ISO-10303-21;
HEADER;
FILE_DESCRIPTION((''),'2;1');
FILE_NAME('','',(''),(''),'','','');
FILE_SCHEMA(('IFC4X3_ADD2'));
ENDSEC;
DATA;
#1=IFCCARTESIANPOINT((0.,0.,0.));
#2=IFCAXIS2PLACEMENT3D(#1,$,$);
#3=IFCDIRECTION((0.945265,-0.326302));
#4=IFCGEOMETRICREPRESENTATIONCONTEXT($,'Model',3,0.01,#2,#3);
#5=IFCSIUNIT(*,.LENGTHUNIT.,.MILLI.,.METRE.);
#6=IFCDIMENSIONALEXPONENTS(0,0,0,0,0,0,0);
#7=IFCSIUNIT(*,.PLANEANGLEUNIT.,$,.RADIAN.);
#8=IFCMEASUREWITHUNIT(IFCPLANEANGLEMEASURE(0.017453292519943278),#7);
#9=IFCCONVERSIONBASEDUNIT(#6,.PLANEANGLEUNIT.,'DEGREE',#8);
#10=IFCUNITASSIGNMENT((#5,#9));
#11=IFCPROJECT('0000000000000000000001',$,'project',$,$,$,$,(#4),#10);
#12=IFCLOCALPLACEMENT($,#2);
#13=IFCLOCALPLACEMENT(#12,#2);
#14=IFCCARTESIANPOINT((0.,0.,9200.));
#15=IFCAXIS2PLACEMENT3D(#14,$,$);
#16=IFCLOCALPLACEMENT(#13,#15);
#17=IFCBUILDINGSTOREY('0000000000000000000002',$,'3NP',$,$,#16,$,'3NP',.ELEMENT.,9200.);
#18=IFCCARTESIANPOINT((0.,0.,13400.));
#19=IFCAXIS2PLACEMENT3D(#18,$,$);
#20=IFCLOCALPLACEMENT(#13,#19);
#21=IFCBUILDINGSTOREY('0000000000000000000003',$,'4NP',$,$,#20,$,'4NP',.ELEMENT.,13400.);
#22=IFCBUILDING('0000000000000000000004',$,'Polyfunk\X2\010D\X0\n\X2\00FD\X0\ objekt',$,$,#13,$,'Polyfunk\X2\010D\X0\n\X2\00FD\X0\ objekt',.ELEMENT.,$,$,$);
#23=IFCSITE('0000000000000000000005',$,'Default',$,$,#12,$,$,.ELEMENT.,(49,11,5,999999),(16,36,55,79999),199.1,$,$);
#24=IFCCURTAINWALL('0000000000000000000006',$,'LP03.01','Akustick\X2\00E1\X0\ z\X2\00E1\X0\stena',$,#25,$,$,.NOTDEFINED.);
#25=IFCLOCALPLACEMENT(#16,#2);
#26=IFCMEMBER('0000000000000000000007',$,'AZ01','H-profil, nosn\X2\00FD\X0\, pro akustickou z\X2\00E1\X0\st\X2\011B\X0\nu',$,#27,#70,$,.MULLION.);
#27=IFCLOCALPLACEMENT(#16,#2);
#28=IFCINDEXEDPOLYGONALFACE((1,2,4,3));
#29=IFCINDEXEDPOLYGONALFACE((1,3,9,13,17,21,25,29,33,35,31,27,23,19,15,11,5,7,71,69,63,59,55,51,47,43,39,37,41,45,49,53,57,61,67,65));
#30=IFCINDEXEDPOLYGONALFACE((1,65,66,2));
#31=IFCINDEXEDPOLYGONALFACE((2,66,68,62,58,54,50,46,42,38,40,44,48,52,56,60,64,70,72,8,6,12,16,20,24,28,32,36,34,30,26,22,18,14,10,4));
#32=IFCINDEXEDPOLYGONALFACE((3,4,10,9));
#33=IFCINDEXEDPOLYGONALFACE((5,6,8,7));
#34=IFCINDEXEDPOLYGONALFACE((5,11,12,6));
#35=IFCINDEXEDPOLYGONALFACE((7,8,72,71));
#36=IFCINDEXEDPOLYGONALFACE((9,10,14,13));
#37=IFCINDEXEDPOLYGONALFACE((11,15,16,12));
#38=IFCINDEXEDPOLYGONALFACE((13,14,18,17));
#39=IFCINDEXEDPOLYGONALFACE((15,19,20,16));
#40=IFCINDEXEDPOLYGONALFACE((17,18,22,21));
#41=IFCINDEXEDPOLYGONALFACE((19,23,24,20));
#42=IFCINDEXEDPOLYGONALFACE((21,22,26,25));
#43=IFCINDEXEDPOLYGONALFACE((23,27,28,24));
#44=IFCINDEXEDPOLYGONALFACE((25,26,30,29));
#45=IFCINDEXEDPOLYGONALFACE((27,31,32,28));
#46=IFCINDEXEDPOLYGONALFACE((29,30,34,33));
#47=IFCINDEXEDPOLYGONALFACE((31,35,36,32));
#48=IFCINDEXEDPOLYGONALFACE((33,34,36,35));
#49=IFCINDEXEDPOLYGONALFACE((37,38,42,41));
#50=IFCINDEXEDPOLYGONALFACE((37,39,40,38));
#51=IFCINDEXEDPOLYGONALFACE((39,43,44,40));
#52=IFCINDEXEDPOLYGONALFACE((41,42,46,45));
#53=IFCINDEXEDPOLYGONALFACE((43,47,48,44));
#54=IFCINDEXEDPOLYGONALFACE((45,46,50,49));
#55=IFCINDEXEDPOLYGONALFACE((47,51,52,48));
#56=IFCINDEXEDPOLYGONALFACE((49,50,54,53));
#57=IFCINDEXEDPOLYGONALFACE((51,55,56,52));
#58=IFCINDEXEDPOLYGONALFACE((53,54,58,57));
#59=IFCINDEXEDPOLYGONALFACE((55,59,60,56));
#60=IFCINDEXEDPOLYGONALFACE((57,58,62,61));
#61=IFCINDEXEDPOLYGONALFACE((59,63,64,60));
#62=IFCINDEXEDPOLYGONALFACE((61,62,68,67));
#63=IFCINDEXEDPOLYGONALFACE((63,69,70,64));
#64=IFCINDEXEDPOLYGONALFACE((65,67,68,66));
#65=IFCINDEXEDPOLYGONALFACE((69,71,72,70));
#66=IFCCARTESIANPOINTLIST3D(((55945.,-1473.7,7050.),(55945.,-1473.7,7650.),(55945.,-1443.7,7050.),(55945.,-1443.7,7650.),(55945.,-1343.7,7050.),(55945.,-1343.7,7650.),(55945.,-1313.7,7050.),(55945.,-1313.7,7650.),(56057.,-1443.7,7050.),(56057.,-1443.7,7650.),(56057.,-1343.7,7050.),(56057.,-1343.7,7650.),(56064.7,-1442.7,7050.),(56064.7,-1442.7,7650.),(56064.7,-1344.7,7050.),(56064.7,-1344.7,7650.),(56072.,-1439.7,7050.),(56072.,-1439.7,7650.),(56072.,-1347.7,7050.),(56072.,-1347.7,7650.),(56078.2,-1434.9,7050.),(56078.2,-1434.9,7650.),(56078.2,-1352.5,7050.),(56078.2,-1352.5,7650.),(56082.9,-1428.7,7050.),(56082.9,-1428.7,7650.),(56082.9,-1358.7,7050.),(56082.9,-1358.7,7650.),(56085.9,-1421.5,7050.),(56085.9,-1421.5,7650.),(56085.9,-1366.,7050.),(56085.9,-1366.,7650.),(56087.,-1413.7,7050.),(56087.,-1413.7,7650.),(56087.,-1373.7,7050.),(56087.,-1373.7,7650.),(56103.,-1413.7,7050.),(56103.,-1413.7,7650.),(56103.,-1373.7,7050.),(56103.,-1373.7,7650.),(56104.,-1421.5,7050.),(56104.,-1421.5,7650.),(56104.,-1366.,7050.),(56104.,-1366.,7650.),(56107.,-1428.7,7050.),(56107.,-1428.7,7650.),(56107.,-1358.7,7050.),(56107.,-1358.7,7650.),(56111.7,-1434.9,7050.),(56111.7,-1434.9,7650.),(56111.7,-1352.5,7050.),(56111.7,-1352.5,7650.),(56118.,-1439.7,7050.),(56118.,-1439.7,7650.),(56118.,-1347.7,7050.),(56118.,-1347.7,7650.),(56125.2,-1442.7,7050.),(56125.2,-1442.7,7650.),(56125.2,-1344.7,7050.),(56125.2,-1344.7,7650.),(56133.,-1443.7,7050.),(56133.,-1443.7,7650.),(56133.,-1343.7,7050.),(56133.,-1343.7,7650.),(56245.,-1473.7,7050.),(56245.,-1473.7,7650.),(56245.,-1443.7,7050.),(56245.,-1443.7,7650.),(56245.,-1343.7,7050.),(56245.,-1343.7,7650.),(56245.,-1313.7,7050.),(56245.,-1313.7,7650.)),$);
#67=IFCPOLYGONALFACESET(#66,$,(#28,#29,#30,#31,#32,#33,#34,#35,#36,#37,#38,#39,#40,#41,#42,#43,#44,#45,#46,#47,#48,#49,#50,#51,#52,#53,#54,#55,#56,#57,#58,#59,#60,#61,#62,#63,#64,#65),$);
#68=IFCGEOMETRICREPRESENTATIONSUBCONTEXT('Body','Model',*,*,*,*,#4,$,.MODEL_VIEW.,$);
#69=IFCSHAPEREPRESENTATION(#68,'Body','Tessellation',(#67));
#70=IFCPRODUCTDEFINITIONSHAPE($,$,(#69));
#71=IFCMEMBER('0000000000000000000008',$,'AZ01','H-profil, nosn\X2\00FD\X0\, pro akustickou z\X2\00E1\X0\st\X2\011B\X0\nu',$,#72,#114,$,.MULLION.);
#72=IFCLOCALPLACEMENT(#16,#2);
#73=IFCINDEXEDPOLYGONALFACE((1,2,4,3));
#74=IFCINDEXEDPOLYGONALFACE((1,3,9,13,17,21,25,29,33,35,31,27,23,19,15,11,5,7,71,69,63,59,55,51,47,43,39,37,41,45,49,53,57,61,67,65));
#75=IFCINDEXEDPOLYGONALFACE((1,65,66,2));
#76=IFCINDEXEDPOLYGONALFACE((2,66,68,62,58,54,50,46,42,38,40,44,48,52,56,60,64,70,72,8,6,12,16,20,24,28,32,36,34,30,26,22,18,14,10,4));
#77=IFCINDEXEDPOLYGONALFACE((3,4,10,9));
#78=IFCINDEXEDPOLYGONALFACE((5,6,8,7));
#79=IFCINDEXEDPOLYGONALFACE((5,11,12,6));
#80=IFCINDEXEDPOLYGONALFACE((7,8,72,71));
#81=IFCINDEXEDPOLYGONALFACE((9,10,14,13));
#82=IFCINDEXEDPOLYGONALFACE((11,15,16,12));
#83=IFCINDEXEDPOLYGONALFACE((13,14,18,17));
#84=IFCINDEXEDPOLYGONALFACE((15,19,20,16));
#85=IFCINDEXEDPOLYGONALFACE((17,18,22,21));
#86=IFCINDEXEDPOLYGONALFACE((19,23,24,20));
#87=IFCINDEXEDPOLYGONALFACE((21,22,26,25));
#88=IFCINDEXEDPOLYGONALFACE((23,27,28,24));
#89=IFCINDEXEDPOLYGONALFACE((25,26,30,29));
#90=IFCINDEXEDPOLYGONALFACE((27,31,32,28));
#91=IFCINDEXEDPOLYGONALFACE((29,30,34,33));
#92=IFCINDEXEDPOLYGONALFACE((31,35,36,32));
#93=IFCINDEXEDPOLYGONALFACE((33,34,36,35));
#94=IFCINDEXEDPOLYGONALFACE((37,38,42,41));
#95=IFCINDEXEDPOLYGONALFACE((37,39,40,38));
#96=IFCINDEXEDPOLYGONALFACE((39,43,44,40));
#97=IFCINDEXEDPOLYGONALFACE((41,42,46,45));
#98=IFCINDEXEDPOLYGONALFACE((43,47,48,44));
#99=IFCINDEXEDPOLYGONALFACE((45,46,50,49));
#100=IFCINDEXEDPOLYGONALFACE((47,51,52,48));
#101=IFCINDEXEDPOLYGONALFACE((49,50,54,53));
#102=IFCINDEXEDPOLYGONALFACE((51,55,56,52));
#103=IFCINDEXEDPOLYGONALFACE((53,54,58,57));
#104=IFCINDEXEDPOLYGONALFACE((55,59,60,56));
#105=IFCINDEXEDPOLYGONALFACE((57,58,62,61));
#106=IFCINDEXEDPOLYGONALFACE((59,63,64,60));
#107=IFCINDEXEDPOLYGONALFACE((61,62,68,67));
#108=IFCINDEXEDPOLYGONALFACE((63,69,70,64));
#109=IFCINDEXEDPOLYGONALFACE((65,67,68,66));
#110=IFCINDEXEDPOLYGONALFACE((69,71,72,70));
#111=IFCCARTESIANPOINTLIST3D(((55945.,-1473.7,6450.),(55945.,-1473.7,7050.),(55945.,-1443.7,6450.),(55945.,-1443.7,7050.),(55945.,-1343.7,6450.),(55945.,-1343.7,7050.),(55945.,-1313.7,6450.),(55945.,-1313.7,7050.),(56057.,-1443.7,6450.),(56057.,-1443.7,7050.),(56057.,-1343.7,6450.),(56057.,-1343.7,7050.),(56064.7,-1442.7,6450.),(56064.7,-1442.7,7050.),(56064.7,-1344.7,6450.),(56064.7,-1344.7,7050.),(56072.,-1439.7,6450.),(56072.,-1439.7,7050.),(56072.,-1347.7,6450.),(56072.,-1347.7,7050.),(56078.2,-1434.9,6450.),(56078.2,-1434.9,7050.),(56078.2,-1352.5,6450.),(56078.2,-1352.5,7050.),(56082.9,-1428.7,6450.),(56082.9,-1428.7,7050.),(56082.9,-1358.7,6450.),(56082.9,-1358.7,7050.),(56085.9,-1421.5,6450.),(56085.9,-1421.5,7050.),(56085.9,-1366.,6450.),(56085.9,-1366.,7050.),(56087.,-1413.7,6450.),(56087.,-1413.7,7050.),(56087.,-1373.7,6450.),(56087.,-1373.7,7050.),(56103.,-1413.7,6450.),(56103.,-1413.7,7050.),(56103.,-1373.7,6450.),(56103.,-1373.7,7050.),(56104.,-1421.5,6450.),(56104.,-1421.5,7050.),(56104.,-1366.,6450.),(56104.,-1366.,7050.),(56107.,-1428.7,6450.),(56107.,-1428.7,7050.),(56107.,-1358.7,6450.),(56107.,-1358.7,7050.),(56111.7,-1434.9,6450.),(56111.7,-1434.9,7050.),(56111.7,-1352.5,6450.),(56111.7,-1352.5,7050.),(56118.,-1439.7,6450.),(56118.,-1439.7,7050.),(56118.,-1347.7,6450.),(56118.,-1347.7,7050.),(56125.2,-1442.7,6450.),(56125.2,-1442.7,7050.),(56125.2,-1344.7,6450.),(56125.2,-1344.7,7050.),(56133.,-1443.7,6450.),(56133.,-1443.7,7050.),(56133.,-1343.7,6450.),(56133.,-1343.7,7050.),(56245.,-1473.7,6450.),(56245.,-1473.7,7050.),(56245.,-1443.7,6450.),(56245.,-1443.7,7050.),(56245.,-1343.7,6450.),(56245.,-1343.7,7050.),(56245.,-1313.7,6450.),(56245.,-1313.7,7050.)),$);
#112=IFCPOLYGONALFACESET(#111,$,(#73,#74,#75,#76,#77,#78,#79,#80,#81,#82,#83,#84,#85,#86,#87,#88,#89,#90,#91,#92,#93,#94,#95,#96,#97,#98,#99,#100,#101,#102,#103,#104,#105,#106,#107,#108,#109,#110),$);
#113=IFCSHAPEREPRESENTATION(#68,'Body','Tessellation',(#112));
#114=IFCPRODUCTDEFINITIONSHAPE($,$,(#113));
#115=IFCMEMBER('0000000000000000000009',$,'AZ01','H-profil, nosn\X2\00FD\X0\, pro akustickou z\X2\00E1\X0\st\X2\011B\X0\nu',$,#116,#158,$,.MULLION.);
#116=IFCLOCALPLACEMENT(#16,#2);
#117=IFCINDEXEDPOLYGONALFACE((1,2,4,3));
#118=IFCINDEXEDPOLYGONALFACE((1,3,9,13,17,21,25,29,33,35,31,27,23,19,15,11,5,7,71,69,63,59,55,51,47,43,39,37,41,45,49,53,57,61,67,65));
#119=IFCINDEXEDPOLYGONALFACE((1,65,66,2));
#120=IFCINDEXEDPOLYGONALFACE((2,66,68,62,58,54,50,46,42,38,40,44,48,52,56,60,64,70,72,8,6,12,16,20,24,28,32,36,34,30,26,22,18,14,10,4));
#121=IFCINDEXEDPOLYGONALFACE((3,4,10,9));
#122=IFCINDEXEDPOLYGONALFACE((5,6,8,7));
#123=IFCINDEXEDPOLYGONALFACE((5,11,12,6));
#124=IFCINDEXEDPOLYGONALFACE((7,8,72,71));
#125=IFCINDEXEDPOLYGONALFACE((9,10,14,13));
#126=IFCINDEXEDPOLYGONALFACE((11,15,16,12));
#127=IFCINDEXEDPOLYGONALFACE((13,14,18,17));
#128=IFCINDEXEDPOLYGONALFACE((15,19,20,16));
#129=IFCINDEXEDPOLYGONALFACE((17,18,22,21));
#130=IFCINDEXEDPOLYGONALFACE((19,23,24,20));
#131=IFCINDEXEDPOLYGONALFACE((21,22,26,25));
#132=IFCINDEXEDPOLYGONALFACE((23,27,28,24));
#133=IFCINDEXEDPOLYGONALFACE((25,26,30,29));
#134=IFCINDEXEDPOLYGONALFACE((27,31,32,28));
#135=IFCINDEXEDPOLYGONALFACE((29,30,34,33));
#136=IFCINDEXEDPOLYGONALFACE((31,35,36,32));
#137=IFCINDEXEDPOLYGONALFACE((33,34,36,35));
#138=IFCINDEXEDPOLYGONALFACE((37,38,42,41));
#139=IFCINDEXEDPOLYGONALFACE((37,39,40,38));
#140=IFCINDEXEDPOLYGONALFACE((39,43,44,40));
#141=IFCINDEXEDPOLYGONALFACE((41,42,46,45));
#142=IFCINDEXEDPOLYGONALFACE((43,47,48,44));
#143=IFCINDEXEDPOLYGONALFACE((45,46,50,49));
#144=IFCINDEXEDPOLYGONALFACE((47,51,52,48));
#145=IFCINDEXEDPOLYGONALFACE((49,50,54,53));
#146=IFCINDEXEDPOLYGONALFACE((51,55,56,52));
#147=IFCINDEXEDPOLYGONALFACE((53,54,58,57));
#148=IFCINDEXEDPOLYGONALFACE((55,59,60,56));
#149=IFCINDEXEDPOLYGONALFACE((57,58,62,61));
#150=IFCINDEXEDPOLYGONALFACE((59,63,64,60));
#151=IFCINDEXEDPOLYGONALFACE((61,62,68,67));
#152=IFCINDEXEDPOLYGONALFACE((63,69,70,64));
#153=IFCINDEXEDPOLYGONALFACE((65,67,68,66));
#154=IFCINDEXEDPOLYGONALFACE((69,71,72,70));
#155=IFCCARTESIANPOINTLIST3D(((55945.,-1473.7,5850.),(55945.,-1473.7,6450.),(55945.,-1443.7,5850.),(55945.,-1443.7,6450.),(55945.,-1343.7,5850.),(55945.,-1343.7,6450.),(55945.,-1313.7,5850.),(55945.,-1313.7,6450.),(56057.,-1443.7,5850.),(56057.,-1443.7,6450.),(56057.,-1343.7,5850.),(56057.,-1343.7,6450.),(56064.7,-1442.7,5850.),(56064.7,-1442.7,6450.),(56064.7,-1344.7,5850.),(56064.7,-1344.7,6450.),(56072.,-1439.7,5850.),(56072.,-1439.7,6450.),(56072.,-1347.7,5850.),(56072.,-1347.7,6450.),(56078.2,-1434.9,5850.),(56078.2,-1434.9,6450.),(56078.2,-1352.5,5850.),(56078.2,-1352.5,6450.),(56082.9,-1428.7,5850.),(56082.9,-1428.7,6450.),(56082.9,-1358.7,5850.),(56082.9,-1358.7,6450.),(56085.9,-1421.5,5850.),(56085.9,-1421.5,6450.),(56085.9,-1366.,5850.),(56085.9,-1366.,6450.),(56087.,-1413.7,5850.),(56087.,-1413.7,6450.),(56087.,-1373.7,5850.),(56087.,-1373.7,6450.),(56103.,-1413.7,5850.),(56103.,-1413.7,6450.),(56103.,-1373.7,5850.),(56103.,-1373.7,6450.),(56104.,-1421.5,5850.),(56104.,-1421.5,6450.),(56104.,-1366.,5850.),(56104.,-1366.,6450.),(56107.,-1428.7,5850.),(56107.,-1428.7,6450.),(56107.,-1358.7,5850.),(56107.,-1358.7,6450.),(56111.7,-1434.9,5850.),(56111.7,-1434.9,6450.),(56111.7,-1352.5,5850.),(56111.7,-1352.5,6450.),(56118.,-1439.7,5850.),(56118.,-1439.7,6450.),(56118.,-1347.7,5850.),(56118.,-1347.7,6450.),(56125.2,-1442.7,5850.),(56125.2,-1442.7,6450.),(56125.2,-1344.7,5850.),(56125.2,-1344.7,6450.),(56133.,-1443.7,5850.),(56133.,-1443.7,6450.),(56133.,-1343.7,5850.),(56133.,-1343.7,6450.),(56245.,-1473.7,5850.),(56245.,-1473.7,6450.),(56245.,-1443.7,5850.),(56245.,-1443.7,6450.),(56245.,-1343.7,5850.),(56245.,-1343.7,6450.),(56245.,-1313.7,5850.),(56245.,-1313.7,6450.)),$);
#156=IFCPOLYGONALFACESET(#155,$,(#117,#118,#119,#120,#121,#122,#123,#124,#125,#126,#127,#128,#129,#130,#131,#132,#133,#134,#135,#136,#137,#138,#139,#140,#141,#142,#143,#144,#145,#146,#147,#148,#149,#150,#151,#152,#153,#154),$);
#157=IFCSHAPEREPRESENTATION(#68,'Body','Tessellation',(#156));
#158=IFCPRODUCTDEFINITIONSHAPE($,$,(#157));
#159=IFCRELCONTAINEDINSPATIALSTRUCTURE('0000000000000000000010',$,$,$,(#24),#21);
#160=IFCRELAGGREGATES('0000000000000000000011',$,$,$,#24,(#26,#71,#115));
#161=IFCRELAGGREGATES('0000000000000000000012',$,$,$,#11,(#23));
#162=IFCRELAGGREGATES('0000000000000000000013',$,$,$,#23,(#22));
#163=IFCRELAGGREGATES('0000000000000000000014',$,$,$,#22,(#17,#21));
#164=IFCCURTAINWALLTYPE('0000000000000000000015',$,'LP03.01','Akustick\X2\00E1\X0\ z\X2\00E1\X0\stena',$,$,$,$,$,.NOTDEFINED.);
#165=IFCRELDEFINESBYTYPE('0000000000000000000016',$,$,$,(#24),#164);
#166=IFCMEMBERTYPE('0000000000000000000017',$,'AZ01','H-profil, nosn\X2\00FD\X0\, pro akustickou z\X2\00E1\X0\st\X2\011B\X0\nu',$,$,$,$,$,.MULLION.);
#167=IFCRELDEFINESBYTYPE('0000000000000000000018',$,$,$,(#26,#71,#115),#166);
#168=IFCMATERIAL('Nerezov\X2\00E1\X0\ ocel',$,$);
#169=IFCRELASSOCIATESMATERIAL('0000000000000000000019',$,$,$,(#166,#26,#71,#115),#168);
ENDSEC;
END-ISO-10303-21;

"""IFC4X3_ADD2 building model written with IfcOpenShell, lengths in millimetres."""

from ifc_helpers import new_model, entity, si_unit, converted_unit, direction, frame, frame_2d, origin, place, context, subcontext, project, spatial, polyline, circle_curve, parameter, trimmed, segment, composite_curve, outline, extrude, source, transform, mapped, material, material_profile, profile_set, profile_usage, type_object, element, aggregate, save


model = new_model("IFC4X3_ADD2")

# Units and contexts
model_context = context("Model", 3, precision=0.01, world=origin(), true_north=direction((0.945265, -0.326302)))
body_context = subcontext(model_context, "Body", "Model", "MODEL_VIEW")
ifc_project = project(units=[si_unit("LENGTHUNIT", "METRE", prefix="MILLI"), converted_unit("PLANEANGLEUNIT", "DEGREE", entity("IfcPlaneAngleMeasure", 0.017453292519943278), si_unit("PLANEANGLEUNIT", "RADIAN"), dimensions=[0, 0, 0, 0, 0, 0, 0])], contexts=[model_context])

# Site, building, storey
site_placement = place(None, origin())
site = spatial("IfcSite", under=ifc_project, at=site_placement, Name="Default", CompositionType="ELEMENT", RefLatitude=(49, 11, 5, 999999), RefLongitude=(16, 36, 55, 79999), RefElevation=199.1)
building_placement = place(site_placement, origin())
building = spatial("IfcBuilding", under=site, at=building_placement, Name="Polyfunkčný objekt", LongName="Polyfunkčný objekt", CompositionType="ELEMENT")
storey_1_placement = place(building_placement, frame((0.0, 0.0, 9200.0)))
storey_1 = spatial("IfcBuildingStorey", under=building, at=storey_1_placement, Name="3NP", LongName="3NP", CompositionType="ELEMENT", Elevation=9200.0)

# Shared definitions
storey_2_placement = place(building_placement, frame((0.0, 0.0, 13400.0)))
storey_2 = spatial("IfcBuildingStorey", under=building, at=storey_2_placement, Name="4NP", LongName="4NP", CompositionType="ELEMENT", Elevation=13400.0)

# Curtain wall, members
curtain_wall_type_1 = type_object("IfcCurtainWallType", Name="LP03.01", Description="Akustická zástena", PredefinedType="NOTDEFINED")
ifc_material_1 = material(Name="Nerezová ocel")
ifc_material_profile_1 = material_profile(ifc_material_1, outline(composite_curve([segment(polyline([(50.0, -150.0), (80.0, -150.0)]), True, "CONTINUOUS"), segment(polyline([(80.0, -150.0), (80.0, 150.0)]), True, "CONTINUOUS"), segment(polyline([(80.0, 150.0), (50.0, 150.0)]), True, "CONTINUOUS"), segment(polyline([(50.0, 150.0), (50.0, 38.0)]), True, "CONTINUOUS"), segment(trimmed(circle_curve(frame_2d((20.0, 38.0), x_axis=(0.0, 1.0)), 30.0), [parameter(180.0)], [parameter(270.0)], True, "PARAMETER"), False, "CONTINUOUS"), segment(polyline([(20.0, 8.0), (-20.0, 8.0)]), True, "CONTINUOUS"), segment(trimmed(circle_curve(frame_2d((-20.0, 38.0), x_axis=(0.0, 1.0)), 30.0), [parameter(90.0)], [parameter(180.0)], True, "PARAMETER"), False, "CONTINUOUS"), segment(polyline([(-50.0, 38.0), (-50.0, 150.0)]), True, "CONTINUOUS"), segment(polyline([(-50.0, 150.0), (-80.0, 150.0)]), True, "CONTINUOUS"), segment(polyline([(-80.0, 150.0), (-80.0, -150.0)]), True, "CONTINUOUS"), segment(polyline([(-80.0, -150.0), (-50.0, -150.0)]), True, "CONTINUOUS"), segment(polyline([(-50.0, -150.0), (-50.0, -38.0)]), True, "CONTINUOUS"), segment(trimmed(circle_curve(frame_2d((-20.0, -38.0), x_axis=(0.0, 1.0)), 30.0), [parameter(0.0)], [parameter(90.0)], True, "PARAMETER"), False, "CONTINUOUS"), segment(polyline([(-20.0, -8.0), (20.0, -8.0)]), True, "CONTINUOUS"), segment(trimmed(circle_curve(frame_2d((20.0, -38.0), x_axis=(0.0, 1.0)), 30.0), [parameter(270.0)], [parameter(0.0)], True, "PARAMETER"), False, "CONTINUOUS"), segment(polyline([(50.0, -38.0), (50.0, -150.0)]), True, "CONTINUOUS")], self_intersect=False)), Name="Profil zástena")
ifc_profile_set_1 = profile_set([ifc_material_profile_1], Name="Profil zástena")
ifc_profile_usage_1 = profile_usage(ifc_profile_set_1)
member_type_1 = type_object("IfcMemberType", Name="AZ01", Description="H-profil, nosný, pro akustickou zástěnu", PredefinedType="MULLION", material=ifc_profile_set_1)
curtain_wall_1_placement = place(storey_2_placement, frame((0.0, 0.0, -13400.0)))
curtain_wall_1 = element("IfcCurtainWall", 1, at=curtain_wall_1_placement, inside=storey_2, type_object=curtain_wall_type_1, Name="LP03.01", Description="Akustická zástena", PredefinedType="NOTDEFINED")
shared_shape_1 = source(origin(), body_context, "Body", "SweptSolid", [
    extrude(outline(composite_curve([segment(polyline([(50.0, -150.0), (80.0, -150.0)]), True, "CONTINUOUS"), segment(polyline([(80.0, -150.0), (80.0, 150.0)]), True, "CONTINUOUS"), segment(polyline([(80.0, 150.0), (50.0, 150.0)]), True, "CONTINUOUS"), segment(polyline([(50.0, 150.0), (50.0, 38.0)]), True, "CONTINUOUS"), segment(trimmed(circle_curve(frame_2d((20.0, 38.0), x_axis=(0.0, 1.0)), 30.0), [parameter(180.0)], [parameter(270.0)], True, "PARAMETER"), False, "CONTINUOUS"), segment(polyline([(20.0, 8.0), (-20.0, 8.0)]), True, "CONTINUOUS"), segment(trimmed(circle_curve(frame_2d((-20.0, 38.0), x_axis=(0.0, 1.0)), 30.0), [parameter(90.0)], [parameter(180.0)], True, "PARAMETER"), False, "CONTINUOUS"), segment(polyline([(-50.0, 38.0), (-50.0, 150.0)]), True, "CONTINUOUS"), segment(polyline([(-50.0, 150.0), (-80.0, 150.0)]), True, "CONTINUOUS"), segment(polyline([(-80.0, 150.0), (-80.0, -150.0)]), True, "CONTINUOUS"), segment(polyline([(-80.0, -150.0), (-50.0, -150.0)]), True, "CONTINUOUS"), segment(polyline([(-50.0, -150.0), (-50.0, -38.0)]), True, "CONTINUOUS"), segment(trimmed(circle_curve(frame_2d((-20.0, -38.0), x_axis=(0.0, 1.0)), 30.0), [parameter(0.0)], [parameter(90.0)], True, "PARAMETER"), False, "CONTINUOUS"), segment(polyline([(-20.0, -8.0), (20.0, -8.0)]), True, "CONTINUOUS"), segment(trimmed(circle_curve(frame_2d((20.0, -38.0), x_axis=(0.0, 1.0)), 30.0), [parameter(270.0)], [parameter(0.0)], True, "PARAMETER"), False, "CONTINUOUS"), segment(polyline([(50.0, -38.0), (50.0, -150.0)]), True, "CONTINUOUS")], self_intersect=False)), frame((-150.0, 0.0, -600.0), z_axis=(0.0, 0.0, 1.0), x_axis=(0.0, -1.0, 0.0)), (0.0, 0.0, 1.0), 600.0),
])
member_1_placement = place(curtain_wall_1_placement, frame((56245.0, -1393.7, 16250.0), z_axis=(0.0, 0.0, -1.0), x_axis=(1.0, 0.0, 0.0)))
member_1 = element("IfcMember", 2, at=member_1_placement, type_object=member_type_1, material=ifc_profile_usage_1, Name="AZ01", Description="H-profil, nosný, pro akustickou zástěnu", PredefinedType="MULLION", context=body_context, shape_type="MappedRepresentation", body=[
    mapped(shared_shape_1, transform((0.0, 0.0, 0.0), scale=1.0)),
])
member_2_placement = place(curtain_wall_1_placement, frame((56245.0, -1393.7, 15650.0), z_axis=(0.0, 0.0, -1.0), x_axis=(1.0, 0.0, 0.0)))
member_2 = element("IfcMember", 3, at=member_2_placement, type_object=member_type_1, material=ifc_profile_usage_1, Name="AZ01", Description="H-profil, nosný, pro akustickou zástěnu", PredefinedType="MULLION", context=body_context, shape_type="MappedRepresentation", body=[
    mapped(shared_shape_1, transform((0.0, 0.0, 0.0), scale=1.0)),
])
member_3_placement = place(curtain_wall_1_placement, frame((56245.0, -1393.7, 15050.0), z_axis=(0.0, 0.0, -1.0), x_axis=(1.0, 0.0, 0.0)))
member_3 = element("IfcMember", 4, at=member_3_placement, type_object=member_type_1, material=ifc_profile_usage_1, Name="AZ01", Description="H-profil, nosný, pro akustickou zástěnu", PredefinedType="MULLION", context=body_context, shape_type="MappedRepresentation", body=[
    mapped(shared_shape_1, transform((0.0, 0.0, 0.0), scale=1.0)),
])
aggregate(curtain_wall_1, [member_1, member_2, member_3])

save(model, "model.ifc")
